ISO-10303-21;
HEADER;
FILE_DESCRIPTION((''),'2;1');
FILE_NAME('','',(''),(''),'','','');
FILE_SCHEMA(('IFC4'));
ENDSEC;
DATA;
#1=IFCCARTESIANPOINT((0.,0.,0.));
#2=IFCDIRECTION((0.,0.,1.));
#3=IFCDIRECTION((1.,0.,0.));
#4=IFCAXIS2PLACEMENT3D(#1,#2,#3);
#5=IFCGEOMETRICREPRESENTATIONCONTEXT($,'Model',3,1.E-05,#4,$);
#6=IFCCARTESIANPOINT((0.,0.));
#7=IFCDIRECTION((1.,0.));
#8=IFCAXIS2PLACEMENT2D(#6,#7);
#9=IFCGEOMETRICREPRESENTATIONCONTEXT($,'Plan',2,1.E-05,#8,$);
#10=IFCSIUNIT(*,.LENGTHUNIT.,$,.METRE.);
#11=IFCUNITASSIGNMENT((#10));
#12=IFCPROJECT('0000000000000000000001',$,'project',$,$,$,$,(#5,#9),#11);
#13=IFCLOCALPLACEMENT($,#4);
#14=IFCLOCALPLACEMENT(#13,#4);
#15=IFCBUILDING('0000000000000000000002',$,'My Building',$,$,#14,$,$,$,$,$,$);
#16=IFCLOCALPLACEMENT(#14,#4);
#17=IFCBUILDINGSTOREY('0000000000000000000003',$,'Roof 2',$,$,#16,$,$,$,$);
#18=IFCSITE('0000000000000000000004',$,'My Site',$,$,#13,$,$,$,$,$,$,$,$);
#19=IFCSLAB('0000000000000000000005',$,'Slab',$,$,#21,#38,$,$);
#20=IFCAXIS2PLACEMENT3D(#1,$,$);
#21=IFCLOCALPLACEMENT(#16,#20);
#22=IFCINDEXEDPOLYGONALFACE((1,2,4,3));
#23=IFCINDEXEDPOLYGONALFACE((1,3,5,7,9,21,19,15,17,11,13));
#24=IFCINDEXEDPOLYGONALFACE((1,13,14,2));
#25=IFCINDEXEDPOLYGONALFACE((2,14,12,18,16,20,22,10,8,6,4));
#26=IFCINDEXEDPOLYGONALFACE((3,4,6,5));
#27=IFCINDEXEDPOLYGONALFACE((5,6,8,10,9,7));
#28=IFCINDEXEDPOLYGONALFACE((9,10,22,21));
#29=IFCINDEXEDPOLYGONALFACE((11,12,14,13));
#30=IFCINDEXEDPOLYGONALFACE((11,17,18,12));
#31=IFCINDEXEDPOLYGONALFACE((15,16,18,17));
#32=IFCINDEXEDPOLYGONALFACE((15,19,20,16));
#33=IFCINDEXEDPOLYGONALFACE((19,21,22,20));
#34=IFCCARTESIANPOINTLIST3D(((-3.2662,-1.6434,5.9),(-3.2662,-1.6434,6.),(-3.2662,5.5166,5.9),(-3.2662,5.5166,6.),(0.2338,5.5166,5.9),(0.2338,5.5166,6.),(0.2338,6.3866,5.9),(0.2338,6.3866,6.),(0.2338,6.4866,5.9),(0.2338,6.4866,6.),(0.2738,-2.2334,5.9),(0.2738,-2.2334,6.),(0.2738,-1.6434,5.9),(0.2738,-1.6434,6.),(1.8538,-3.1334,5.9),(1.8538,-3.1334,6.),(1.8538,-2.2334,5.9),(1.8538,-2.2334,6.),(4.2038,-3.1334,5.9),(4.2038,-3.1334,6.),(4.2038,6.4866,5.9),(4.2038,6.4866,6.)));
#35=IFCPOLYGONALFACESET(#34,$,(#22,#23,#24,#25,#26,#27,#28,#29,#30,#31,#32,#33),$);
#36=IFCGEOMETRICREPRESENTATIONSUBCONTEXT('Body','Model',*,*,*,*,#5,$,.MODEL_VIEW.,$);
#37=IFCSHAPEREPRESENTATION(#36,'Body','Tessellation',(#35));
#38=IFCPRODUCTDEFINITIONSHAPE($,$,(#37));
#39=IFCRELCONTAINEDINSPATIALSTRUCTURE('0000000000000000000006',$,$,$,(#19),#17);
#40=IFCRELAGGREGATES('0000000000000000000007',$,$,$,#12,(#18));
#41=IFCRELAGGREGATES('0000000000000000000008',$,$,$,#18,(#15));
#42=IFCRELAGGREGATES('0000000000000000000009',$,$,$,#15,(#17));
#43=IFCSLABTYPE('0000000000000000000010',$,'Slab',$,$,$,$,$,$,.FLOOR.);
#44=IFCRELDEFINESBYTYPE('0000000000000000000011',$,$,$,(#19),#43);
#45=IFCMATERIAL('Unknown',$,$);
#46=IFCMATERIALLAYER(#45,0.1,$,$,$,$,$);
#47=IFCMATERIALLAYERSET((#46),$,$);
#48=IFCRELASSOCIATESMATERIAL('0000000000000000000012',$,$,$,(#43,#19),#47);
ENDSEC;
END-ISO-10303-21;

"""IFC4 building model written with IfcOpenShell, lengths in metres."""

from ifc_helpers import new_model, si_unit, frame, origin_with_axes, origin_2d_with_axis, place, context, subcontext, project, spatial, indexed_curve, outline, extrude, material, layer, layer_set, layer_usage, type_object, element, save


model = new_model("IFC4")

# Units and contexts
model_context = context("Model", 3, precision=1e-05, world=origin_with_axes())
plan_context = context("Plan", 2, precision=1e-05, world=origin_2d_with_axis())
body_context = subcontext(model_context, "Body", "Model", "MODEL_VIEW")
ifc_project = project(units=[si_unit("LENGTHUNIT", "METRE")], contexts=[model_context, plan_context])

# Site, building, storey
site_placement = place(None, origin_with_axes())
site = spatial("IfcSite", under=ifc_project, at=site_placement, Name="My Site")
building_placement = place(site_placement, origin_with_axes())
building = spatial("IfcBuilding", under=site, at=building_placement, Name="My Building")
storey_placement = place(building_placement, origin_with_axes())
storey = spatial("IfcBuildingStorey", under=building, at=storey_placement, Name="Roof 2")

# Slab
ifc_material = material(Name="Unknown")
ifc_layer = layer(ifc_material, 0.1)
ifc_layer_set = layer_set([ifc_layer])
ifc_layer_usage = layer_usage(ifc_layer_set, "AXIS3", "POSITIVE", -0.1)
slab_type = type_object("IfcSlabType", Name="Slab", PredefinedType="FLOOR", material=ifc_layer_set)
slab_placement = place(storey_placement, frame((4.2038, -3.1334, 6.0), z_axis=(0.0, 0.0, 1.0), x_axis=(1.0, 0.0, 0.0)))
element("IfcSlab", 1, at=slab_placement, inside=storey, type_object=slab_type, material=ifc_layer_usage, Name="Slab", context=body_context, shape_type="SweptSolid", body=[
    extrude(outline(indexed_curve([(0.0, 0.0), (-2.35, 0.0), (-2.35, 0.9), (-3.93, 0.9), (-3.93, 1.49), (-7.47, 1.49), (-7.47, 8.65), (-3.97, 8.65), (-3.97, 9.52), (-3.97, 9.62), (0.0, 9.62), (0.0, 0.0)])), frame((0.0, 0.0, -0.1), z_axis=(0.0, 0.0, 1.0), x_axis=(1.0, 0.0, 0.0)), (0.0, 0.0, 1.0), 0.1),
])

save(model, "model.ifc")
